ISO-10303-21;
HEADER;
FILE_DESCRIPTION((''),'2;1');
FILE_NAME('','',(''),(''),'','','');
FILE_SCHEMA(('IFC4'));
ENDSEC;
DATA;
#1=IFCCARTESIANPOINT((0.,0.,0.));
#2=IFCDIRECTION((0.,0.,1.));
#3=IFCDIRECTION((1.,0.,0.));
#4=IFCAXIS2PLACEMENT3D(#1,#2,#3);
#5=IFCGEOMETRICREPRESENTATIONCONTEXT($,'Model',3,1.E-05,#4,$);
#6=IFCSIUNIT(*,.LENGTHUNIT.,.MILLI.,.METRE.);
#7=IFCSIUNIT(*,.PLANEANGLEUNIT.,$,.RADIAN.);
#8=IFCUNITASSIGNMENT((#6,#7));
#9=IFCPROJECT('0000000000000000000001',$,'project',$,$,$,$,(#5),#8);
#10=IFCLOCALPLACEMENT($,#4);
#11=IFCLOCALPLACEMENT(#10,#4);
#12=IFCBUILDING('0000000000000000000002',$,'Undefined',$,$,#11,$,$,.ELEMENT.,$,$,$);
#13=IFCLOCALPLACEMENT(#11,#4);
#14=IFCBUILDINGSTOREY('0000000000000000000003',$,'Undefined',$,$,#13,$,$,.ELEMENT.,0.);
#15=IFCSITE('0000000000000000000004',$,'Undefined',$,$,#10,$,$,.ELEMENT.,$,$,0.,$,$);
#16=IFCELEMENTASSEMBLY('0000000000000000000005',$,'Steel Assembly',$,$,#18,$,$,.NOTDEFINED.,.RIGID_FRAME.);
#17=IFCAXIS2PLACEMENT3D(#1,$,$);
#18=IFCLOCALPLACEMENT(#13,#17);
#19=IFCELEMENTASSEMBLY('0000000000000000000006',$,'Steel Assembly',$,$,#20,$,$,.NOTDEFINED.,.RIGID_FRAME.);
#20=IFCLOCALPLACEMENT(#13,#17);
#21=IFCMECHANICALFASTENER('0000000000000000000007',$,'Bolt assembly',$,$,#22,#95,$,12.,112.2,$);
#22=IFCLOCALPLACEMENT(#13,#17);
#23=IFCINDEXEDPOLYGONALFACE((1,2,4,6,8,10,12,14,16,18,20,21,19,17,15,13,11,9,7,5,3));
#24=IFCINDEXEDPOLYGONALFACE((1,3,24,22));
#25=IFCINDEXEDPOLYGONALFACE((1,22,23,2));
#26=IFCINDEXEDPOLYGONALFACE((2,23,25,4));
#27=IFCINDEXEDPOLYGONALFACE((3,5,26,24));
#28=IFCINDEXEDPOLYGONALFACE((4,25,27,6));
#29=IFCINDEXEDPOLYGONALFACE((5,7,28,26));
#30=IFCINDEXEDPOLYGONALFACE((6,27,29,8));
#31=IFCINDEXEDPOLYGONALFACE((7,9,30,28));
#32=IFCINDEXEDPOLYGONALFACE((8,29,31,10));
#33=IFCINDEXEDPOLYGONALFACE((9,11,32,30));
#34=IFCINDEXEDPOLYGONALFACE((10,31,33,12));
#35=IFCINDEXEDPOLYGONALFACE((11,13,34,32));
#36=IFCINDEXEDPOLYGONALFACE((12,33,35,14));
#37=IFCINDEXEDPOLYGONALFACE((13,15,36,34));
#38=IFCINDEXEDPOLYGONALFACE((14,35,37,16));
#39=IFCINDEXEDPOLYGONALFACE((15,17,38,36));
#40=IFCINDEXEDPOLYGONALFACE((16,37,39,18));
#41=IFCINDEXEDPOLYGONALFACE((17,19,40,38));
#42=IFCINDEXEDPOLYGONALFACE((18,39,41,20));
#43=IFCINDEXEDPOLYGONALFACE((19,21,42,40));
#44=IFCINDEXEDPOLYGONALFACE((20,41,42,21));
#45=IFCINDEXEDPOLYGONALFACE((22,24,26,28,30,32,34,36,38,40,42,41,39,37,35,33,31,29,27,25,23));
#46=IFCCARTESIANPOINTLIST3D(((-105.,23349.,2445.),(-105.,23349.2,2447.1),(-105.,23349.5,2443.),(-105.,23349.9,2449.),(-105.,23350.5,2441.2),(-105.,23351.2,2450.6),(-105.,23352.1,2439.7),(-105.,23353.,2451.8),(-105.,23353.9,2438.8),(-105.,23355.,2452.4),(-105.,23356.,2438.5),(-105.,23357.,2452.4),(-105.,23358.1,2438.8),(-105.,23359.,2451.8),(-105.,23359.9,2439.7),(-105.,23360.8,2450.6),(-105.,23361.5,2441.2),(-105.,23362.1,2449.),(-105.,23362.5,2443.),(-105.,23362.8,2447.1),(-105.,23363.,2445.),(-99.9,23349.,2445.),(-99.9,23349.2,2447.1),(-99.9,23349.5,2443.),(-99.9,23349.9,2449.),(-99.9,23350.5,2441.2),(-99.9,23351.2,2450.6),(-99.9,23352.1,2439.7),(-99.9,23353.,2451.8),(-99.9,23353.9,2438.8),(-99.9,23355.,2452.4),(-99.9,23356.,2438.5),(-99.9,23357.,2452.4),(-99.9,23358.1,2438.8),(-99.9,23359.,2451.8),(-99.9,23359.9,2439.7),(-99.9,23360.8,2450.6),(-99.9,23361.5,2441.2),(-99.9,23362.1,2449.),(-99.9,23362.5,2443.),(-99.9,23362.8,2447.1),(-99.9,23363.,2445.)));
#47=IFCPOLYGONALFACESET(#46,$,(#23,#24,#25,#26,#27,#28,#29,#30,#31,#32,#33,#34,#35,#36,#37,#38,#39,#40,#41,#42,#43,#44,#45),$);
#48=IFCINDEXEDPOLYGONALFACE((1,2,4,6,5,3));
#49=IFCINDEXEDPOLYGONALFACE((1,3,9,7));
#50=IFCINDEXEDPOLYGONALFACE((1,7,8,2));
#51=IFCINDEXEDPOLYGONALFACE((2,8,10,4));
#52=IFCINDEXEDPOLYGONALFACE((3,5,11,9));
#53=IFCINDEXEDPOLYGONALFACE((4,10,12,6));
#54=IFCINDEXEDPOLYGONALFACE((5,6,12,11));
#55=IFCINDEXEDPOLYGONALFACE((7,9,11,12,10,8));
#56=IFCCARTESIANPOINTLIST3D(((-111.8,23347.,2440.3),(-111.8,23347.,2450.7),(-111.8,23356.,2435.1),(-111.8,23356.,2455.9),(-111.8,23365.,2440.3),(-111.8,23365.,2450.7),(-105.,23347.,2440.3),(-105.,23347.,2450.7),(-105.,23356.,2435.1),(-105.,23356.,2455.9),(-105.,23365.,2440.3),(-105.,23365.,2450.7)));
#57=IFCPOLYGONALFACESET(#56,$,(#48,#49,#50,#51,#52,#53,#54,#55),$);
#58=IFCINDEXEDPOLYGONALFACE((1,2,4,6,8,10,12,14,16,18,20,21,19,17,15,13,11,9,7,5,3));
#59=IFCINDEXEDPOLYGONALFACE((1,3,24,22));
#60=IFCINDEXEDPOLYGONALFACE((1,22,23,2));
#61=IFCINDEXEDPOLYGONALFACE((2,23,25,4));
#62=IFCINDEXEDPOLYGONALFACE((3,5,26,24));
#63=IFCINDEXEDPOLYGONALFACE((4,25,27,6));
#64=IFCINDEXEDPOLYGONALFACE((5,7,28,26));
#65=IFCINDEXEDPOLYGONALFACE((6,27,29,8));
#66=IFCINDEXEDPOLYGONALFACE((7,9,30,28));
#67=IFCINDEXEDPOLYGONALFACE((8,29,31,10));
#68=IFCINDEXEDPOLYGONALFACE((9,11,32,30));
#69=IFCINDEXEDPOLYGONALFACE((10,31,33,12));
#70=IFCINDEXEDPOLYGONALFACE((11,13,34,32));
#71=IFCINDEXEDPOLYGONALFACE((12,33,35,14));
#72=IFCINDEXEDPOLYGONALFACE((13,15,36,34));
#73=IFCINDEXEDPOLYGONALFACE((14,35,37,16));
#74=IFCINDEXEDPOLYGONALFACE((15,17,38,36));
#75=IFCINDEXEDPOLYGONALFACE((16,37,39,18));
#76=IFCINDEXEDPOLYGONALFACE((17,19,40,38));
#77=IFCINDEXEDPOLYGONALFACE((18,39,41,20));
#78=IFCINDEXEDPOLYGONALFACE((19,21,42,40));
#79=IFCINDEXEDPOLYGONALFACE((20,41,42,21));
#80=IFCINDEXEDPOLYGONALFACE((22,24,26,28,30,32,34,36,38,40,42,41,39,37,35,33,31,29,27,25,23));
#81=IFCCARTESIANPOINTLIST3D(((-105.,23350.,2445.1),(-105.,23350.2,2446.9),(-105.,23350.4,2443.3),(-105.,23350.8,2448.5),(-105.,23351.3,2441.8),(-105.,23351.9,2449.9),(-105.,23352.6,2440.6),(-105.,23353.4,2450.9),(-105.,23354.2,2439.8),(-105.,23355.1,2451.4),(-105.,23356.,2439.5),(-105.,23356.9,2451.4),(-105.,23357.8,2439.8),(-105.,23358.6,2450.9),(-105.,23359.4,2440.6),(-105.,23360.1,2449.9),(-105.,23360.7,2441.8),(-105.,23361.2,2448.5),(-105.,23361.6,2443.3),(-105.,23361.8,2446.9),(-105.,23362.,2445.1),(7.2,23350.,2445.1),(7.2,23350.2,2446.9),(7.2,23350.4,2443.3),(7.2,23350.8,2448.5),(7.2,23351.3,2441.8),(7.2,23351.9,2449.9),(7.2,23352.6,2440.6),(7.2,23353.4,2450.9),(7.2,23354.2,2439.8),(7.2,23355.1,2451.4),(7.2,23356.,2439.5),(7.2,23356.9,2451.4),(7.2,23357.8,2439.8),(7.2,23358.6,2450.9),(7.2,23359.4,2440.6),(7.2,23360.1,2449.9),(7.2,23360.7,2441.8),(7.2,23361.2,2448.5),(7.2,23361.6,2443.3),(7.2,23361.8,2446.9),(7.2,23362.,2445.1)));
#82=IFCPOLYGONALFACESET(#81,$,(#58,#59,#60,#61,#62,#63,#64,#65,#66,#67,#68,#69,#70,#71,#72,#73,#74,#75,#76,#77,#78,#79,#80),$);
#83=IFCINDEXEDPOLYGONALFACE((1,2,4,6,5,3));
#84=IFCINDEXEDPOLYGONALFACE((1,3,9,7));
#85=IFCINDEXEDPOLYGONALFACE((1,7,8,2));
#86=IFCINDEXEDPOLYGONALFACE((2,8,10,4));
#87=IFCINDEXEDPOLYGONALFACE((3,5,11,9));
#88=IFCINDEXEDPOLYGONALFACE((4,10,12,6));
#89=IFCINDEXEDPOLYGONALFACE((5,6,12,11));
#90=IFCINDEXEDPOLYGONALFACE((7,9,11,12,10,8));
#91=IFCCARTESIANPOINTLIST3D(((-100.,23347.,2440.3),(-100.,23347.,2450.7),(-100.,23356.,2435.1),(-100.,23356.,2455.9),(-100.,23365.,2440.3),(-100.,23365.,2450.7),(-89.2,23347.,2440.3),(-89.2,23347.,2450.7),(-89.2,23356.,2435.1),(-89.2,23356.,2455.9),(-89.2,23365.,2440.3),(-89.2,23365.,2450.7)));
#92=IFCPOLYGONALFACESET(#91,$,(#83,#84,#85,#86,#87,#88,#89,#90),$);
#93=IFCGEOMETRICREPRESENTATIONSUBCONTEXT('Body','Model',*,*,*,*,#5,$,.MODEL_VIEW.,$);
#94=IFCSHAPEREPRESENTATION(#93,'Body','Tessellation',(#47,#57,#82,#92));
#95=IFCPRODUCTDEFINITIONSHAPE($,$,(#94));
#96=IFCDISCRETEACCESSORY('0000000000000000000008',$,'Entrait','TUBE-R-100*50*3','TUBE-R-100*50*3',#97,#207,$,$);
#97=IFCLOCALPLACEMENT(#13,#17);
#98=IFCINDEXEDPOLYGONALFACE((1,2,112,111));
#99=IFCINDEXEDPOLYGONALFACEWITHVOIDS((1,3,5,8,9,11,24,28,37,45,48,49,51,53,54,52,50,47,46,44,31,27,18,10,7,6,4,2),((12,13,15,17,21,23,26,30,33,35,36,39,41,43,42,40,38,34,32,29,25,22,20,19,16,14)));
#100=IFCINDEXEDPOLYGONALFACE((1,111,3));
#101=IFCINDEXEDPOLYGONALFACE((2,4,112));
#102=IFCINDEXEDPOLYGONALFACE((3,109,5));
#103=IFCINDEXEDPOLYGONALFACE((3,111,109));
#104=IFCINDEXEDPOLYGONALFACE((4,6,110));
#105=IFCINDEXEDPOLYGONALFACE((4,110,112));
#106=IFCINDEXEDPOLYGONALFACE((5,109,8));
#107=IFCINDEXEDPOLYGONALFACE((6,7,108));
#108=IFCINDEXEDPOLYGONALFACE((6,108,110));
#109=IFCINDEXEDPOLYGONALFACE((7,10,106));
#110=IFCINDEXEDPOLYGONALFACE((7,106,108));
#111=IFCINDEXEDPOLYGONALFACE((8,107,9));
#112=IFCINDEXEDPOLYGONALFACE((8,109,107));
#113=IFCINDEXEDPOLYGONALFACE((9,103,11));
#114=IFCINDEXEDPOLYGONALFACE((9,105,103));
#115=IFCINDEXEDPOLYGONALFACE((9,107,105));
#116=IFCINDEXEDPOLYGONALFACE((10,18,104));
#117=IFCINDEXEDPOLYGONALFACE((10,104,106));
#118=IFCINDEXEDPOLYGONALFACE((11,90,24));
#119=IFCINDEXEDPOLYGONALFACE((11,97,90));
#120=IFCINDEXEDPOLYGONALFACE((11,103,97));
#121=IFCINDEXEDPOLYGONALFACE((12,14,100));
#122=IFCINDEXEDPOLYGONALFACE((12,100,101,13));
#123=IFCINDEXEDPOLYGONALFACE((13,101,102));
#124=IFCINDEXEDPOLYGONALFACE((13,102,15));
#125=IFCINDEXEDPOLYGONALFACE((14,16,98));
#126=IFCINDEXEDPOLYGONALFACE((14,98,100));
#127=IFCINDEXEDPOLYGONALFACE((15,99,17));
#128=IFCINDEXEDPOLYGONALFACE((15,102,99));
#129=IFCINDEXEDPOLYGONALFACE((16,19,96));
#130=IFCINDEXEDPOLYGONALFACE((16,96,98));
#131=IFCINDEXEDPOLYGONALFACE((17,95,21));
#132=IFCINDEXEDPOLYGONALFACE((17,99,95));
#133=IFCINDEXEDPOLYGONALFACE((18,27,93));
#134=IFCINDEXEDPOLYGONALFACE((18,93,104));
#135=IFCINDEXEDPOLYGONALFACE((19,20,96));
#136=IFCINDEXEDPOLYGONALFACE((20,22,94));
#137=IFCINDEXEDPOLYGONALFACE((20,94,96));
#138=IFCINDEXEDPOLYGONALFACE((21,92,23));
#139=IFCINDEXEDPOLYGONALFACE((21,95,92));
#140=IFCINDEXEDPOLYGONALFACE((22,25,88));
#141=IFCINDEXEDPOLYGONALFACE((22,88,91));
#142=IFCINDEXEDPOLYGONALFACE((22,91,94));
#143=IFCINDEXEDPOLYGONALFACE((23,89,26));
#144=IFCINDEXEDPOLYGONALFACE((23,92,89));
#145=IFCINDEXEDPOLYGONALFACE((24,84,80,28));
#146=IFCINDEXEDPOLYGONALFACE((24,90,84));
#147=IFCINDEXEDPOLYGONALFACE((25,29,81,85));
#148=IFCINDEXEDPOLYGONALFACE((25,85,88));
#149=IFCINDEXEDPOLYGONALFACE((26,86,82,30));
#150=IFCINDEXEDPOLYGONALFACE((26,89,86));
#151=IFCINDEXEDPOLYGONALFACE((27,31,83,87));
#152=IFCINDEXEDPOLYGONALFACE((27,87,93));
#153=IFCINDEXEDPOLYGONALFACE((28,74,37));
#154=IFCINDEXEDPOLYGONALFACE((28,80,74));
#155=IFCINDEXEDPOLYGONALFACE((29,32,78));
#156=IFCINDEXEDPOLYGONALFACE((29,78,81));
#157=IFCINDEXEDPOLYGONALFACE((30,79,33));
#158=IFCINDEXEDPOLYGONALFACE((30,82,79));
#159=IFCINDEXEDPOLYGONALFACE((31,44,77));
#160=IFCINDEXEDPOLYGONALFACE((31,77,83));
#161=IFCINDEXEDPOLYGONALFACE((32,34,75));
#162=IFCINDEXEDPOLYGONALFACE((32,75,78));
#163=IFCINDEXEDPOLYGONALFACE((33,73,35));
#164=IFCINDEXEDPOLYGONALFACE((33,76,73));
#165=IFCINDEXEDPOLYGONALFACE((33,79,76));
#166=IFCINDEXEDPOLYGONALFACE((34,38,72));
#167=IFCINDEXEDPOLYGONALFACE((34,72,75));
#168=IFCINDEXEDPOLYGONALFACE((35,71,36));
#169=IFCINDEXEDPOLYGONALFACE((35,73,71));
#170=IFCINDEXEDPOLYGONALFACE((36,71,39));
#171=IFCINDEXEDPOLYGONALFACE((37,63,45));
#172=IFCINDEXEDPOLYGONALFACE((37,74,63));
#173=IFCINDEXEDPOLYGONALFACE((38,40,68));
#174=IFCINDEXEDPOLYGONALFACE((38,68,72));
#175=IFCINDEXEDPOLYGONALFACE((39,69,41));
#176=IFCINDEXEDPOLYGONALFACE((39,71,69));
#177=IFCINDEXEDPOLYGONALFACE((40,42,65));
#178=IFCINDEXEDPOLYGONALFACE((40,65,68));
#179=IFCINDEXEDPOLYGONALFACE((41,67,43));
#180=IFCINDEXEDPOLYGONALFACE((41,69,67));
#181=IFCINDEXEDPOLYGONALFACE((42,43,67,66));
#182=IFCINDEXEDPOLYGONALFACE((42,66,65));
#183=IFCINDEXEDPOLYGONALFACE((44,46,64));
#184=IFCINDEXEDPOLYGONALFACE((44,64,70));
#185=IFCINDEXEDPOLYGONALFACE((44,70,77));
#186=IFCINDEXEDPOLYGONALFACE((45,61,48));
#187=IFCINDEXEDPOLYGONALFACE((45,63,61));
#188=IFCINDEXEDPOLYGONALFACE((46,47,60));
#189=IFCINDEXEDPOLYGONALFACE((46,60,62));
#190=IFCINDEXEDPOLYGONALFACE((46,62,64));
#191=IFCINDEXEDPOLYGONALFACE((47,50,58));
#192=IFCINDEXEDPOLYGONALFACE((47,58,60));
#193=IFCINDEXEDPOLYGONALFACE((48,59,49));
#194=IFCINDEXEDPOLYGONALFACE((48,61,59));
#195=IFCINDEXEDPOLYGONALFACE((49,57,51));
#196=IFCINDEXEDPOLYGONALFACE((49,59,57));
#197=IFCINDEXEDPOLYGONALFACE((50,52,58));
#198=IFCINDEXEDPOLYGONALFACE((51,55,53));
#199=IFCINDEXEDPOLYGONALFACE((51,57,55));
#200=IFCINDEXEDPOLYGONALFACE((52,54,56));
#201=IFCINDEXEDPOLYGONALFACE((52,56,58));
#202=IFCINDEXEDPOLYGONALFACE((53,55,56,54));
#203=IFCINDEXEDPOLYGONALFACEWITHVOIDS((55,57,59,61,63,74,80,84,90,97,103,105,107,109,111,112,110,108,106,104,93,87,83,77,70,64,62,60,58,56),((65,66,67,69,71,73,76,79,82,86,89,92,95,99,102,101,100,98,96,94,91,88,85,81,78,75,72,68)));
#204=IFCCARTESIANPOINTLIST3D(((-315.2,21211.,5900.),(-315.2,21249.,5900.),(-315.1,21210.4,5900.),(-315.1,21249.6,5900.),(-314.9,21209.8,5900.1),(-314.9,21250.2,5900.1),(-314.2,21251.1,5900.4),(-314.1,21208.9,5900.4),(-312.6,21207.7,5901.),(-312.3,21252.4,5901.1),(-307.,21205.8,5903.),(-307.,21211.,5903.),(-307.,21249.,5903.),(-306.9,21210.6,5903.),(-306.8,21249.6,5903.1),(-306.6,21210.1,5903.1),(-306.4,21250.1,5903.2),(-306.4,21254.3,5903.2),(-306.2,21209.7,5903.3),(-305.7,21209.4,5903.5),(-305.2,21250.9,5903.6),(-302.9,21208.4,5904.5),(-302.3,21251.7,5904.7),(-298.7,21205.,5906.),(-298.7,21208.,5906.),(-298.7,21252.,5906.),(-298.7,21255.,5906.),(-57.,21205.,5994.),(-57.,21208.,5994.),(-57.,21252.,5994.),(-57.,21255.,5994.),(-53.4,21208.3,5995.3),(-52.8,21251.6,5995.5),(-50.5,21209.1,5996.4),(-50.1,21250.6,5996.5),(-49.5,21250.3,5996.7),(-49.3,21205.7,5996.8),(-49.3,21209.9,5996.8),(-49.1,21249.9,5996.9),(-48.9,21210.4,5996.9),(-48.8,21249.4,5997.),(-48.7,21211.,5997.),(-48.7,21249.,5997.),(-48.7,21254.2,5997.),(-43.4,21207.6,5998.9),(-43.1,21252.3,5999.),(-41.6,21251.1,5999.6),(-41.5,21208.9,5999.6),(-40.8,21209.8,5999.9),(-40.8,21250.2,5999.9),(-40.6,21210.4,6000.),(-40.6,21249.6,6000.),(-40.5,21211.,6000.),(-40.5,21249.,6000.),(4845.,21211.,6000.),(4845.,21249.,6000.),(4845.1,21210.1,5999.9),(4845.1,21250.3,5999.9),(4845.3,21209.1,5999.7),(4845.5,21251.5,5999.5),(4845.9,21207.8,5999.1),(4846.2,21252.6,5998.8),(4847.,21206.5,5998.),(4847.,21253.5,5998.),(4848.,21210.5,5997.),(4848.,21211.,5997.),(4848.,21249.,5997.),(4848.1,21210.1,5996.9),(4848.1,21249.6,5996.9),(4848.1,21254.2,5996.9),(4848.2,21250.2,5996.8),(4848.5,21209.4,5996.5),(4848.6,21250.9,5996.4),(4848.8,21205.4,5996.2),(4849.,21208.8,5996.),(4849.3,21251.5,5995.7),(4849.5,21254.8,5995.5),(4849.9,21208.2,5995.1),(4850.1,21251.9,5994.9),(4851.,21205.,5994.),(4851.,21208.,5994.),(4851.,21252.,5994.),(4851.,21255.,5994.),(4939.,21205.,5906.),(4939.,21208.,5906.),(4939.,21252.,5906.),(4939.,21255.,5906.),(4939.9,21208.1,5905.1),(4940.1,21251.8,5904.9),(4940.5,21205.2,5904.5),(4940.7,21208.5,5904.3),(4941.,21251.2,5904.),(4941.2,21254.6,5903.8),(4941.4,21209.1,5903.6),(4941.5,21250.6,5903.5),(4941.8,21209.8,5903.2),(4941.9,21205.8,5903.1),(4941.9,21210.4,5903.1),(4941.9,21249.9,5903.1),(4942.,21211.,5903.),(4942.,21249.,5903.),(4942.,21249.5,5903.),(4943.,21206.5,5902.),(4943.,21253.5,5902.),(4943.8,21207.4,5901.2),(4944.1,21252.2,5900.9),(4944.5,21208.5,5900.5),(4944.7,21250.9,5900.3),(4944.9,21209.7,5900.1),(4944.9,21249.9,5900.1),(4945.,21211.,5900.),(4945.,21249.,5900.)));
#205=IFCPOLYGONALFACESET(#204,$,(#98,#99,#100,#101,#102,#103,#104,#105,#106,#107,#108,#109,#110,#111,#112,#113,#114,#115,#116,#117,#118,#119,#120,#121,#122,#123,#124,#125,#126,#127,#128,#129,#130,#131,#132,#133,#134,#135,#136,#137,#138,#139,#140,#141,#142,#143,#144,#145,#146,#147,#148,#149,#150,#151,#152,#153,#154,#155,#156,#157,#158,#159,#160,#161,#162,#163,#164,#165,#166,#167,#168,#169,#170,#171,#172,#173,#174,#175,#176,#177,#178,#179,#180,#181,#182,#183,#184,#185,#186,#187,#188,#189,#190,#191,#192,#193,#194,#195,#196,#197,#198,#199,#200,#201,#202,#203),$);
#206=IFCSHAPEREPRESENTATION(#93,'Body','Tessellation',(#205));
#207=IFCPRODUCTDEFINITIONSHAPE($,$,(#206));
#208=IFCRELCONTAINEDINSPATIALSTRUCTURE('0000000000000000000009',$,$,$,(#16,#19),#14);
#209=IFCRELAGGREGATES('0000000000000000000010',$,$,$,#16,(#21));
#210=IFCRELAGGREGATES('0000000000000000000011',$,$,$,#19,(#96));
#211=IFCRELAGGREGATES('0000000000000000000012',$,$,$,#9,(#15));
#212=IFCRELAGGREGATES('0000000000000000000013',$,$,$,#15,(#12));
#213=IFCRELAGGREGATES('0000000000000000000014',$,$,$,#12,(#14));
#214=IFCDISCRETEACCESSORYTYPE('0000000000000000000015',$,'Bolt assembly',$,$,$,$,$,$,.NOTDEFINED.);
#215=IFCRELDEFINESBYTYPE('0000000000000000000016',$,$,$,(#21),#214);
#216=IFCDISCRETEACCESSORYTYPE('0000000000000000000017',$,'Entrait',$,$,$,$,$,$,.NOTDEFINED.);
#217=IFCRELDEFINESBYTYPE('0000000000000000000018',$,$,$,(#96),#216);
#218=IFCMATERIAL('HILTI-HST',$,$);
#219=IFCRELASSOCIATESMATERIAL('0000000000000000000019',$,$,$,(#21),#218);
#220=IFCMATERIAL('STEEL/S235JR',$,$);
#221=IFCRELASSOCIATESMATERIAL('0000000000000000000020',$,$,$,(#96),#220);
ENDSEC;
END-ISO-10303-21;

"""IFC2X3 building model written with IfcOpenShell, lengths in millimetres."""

from ifc_helpers import new_model, si_unit, frame, origin_with_axes, origin_2d_with_axis, place, context, subcontext, project, spatial, polyline, hollow_rectangle, circle, outline, extrude, clip, halfspace, source, transform, mapped, material, type_object, element, aggregate, save


model = new_model("IFC2X3")

# Units and contexts
model_context = context("Model", 3, precision=1e-05, world=origin_with_axes())
body_context = subcontext(model_context, "Body", "Model", "MODEL_VIEW")
ifc_project = project(units=[si_unit("LENGTHUNIT", "METRE", prefix="MILLI"), si_unit("PLANEANGLEUNIT", "RADIAN")], contexts=[model_context])

# Site, building, storey
site_placement = place(None, origin_with_axes())
site = spatial("IfcSite", under=ifc_project, at=site_placement, Name="Undefined", CompositionType="ELEMENT", RefElevation=0.0)
building_placement = place(site_placement, origin_with_axes())
building = spatial("IfcBuilding", under=site, at=building_placement, Name="Undefined", CompositionType="ELEMENT")
storey_placement = place(building_placement, origin_with_axes())
storey = spatial("IfcBuildingStorey", under=building, at=storey_placement, Name="Undefined", CompositionType="ELEMENT", Elevation=0.0)

# Element assemblies
assembly_1_placement = place(storey_placement, origin_with_axes())
assembly_1 = element("IfcElementAssembly", 1, at=assembly_1_placement, inside=storey, Name="Steel Assembly", AssemblyPlace="NOTDEFINED", PredefinedType="RIGID_FRAME")
ifc_material_1 = material(Name="STEEL/S235JR")
assembly_2_placement = place(storey_placement, origin_with_axes())
assembly_2 = element("IfcElementAssembly", 2, at=assembly_2_placement, inside=storey, Name="Steel Assembly", AssemblyPlace="NOTDEFINED", PredefinedType="RIGID_FRAME")

# Shared definitions
discrete_accessory_type_1 = type_object("IfcDiscreteAccessoryType", Name="Bolt assembly")

# Mechanical fastener
ifc_material_2 = material(Name="HILTI-HST")
shared_shape_1 = source(origin_with_axes(), body_context, "Body", "SweptSolid", [
    extrude(circle(Radius=7.0, at=origin_2d_with_axis()), frame((0.0, -5.0, 0.0), z_axis=(0.0, 1.0, 0.0), x_axis=(1.0, 0.0, 0.0)), (0.0, 0.0, 1.0), 5.1),
    extrude(outline(polyline([(10.4, 0.0), (5.2, 9.0), (-5.2, 9.0), (-10.4, 0.0), (-5.2, -9.0), (5.2, -9.0), (10.4, 0.0)])), frame((0.0, -11.8, 0.0), z_axis=(0.0, 1.0, 0.0), x_axis=(1.0, 0.0, 0.0)), (0.0, 0.0, 1.0), 6.8),
    extrude(circle(Radius=6.0, at=origin_2d_with_axis()), frame((0.0, -5.0, 0.0), z_axis=(0.0, 1.0, 0.0), x_axis=(1.0, 0.0, 0.0)), (0.0, 0.0, 1.0), 112.2),
    extrude(outline(polyline([(10.4, 0.0), (5.2, 9.0), (-5.2, 9.0), (-10.4, 0.0), (-5.2, -9.0), (5.2, -9.0), (10.4, 0.0)])), frame((0.0, 0.0, 0.0), z_axis=(0.0, 1.0, 0.0), x_axis=(1.0, 0.0, 0.0)), (0.0, 0.0, 1.0), 10.8),
])
mechanical_fastener_1_placement = place(assembly_1_placement, frame((-100.0, 23356.0, 2445.5), z_axis=(0.0, -1.0, 0.0), x_axis=(0.0, 0.0, -1.0)))
mechanical_fastener_1 = element("IfcMechanicalFastener", 3, at=mechanical_fastener_1_placement, type_object=discrete_accessory_type_1, material=ifc_material_2, Name="Bolt assembly", NominalDiameter=12.0, NominalLength=112.2, context=body_context, shape_type="MappedRepresentation", body=[
    mapped(shared_shape_1, transform((0.0, 0.0, 0.0))),
])
aggregate(assembly_1, [mechanical_fastener_1])

# Discrete accessory
discrete_accessory_type_2 = type_object("IfcDiscreteAccessoryType", Name="Entrait")
discrete_accessory_1_placement = place(assembly_2_placement, frame((-404.2, 21230.0, 5950.0), z_axis=(0.0, 0.0, 1.0), x_axis=(1.0, 0.0, 0.0)))
discrete_accessory_1 = element("IfcDiscreteAccessory", 4, at=discrete_accessory_1_placement, type_object=discrete_accessory_type_2, material=ifc_material_1, Name="Entrait", Description="TUBE-R-100*50*3", ObjectType="TUBE-R-100*50*3", context=body_context, shape_type="Clipping", body=[
    clip(clip(extrude(hollow_rectangle(XDim=50.0, YDim=100.0, WallThickness=3.0, InnerFilletRadius=3.0, OuterFilletRadius=6.0, at=origin_2d_with_axis()), frame((5488.5, 0.0, 0.0), z_axis=(-1.0, 0.0, 0.0), x_axis=(0.0, -1.0, 0.0)), (0.0, 0.0, 1.0), 5451.3), halfspace(frame((5249.2, -25.0, 50.0), z_axis=(-0.707107, 0.0, -0.707107), x_axis=(0.0, -1.0, 0.0)), True)), halfspace(frame((115.1, 0.0, -40.5), z_axis=(0.34202, 0.0, -0.939693), x_axis=(0.0, -1.0, 0.0)), True)),
])

aggregate(assembly_2, [discrete_accessory_1])

save(model, "model.ifc")
